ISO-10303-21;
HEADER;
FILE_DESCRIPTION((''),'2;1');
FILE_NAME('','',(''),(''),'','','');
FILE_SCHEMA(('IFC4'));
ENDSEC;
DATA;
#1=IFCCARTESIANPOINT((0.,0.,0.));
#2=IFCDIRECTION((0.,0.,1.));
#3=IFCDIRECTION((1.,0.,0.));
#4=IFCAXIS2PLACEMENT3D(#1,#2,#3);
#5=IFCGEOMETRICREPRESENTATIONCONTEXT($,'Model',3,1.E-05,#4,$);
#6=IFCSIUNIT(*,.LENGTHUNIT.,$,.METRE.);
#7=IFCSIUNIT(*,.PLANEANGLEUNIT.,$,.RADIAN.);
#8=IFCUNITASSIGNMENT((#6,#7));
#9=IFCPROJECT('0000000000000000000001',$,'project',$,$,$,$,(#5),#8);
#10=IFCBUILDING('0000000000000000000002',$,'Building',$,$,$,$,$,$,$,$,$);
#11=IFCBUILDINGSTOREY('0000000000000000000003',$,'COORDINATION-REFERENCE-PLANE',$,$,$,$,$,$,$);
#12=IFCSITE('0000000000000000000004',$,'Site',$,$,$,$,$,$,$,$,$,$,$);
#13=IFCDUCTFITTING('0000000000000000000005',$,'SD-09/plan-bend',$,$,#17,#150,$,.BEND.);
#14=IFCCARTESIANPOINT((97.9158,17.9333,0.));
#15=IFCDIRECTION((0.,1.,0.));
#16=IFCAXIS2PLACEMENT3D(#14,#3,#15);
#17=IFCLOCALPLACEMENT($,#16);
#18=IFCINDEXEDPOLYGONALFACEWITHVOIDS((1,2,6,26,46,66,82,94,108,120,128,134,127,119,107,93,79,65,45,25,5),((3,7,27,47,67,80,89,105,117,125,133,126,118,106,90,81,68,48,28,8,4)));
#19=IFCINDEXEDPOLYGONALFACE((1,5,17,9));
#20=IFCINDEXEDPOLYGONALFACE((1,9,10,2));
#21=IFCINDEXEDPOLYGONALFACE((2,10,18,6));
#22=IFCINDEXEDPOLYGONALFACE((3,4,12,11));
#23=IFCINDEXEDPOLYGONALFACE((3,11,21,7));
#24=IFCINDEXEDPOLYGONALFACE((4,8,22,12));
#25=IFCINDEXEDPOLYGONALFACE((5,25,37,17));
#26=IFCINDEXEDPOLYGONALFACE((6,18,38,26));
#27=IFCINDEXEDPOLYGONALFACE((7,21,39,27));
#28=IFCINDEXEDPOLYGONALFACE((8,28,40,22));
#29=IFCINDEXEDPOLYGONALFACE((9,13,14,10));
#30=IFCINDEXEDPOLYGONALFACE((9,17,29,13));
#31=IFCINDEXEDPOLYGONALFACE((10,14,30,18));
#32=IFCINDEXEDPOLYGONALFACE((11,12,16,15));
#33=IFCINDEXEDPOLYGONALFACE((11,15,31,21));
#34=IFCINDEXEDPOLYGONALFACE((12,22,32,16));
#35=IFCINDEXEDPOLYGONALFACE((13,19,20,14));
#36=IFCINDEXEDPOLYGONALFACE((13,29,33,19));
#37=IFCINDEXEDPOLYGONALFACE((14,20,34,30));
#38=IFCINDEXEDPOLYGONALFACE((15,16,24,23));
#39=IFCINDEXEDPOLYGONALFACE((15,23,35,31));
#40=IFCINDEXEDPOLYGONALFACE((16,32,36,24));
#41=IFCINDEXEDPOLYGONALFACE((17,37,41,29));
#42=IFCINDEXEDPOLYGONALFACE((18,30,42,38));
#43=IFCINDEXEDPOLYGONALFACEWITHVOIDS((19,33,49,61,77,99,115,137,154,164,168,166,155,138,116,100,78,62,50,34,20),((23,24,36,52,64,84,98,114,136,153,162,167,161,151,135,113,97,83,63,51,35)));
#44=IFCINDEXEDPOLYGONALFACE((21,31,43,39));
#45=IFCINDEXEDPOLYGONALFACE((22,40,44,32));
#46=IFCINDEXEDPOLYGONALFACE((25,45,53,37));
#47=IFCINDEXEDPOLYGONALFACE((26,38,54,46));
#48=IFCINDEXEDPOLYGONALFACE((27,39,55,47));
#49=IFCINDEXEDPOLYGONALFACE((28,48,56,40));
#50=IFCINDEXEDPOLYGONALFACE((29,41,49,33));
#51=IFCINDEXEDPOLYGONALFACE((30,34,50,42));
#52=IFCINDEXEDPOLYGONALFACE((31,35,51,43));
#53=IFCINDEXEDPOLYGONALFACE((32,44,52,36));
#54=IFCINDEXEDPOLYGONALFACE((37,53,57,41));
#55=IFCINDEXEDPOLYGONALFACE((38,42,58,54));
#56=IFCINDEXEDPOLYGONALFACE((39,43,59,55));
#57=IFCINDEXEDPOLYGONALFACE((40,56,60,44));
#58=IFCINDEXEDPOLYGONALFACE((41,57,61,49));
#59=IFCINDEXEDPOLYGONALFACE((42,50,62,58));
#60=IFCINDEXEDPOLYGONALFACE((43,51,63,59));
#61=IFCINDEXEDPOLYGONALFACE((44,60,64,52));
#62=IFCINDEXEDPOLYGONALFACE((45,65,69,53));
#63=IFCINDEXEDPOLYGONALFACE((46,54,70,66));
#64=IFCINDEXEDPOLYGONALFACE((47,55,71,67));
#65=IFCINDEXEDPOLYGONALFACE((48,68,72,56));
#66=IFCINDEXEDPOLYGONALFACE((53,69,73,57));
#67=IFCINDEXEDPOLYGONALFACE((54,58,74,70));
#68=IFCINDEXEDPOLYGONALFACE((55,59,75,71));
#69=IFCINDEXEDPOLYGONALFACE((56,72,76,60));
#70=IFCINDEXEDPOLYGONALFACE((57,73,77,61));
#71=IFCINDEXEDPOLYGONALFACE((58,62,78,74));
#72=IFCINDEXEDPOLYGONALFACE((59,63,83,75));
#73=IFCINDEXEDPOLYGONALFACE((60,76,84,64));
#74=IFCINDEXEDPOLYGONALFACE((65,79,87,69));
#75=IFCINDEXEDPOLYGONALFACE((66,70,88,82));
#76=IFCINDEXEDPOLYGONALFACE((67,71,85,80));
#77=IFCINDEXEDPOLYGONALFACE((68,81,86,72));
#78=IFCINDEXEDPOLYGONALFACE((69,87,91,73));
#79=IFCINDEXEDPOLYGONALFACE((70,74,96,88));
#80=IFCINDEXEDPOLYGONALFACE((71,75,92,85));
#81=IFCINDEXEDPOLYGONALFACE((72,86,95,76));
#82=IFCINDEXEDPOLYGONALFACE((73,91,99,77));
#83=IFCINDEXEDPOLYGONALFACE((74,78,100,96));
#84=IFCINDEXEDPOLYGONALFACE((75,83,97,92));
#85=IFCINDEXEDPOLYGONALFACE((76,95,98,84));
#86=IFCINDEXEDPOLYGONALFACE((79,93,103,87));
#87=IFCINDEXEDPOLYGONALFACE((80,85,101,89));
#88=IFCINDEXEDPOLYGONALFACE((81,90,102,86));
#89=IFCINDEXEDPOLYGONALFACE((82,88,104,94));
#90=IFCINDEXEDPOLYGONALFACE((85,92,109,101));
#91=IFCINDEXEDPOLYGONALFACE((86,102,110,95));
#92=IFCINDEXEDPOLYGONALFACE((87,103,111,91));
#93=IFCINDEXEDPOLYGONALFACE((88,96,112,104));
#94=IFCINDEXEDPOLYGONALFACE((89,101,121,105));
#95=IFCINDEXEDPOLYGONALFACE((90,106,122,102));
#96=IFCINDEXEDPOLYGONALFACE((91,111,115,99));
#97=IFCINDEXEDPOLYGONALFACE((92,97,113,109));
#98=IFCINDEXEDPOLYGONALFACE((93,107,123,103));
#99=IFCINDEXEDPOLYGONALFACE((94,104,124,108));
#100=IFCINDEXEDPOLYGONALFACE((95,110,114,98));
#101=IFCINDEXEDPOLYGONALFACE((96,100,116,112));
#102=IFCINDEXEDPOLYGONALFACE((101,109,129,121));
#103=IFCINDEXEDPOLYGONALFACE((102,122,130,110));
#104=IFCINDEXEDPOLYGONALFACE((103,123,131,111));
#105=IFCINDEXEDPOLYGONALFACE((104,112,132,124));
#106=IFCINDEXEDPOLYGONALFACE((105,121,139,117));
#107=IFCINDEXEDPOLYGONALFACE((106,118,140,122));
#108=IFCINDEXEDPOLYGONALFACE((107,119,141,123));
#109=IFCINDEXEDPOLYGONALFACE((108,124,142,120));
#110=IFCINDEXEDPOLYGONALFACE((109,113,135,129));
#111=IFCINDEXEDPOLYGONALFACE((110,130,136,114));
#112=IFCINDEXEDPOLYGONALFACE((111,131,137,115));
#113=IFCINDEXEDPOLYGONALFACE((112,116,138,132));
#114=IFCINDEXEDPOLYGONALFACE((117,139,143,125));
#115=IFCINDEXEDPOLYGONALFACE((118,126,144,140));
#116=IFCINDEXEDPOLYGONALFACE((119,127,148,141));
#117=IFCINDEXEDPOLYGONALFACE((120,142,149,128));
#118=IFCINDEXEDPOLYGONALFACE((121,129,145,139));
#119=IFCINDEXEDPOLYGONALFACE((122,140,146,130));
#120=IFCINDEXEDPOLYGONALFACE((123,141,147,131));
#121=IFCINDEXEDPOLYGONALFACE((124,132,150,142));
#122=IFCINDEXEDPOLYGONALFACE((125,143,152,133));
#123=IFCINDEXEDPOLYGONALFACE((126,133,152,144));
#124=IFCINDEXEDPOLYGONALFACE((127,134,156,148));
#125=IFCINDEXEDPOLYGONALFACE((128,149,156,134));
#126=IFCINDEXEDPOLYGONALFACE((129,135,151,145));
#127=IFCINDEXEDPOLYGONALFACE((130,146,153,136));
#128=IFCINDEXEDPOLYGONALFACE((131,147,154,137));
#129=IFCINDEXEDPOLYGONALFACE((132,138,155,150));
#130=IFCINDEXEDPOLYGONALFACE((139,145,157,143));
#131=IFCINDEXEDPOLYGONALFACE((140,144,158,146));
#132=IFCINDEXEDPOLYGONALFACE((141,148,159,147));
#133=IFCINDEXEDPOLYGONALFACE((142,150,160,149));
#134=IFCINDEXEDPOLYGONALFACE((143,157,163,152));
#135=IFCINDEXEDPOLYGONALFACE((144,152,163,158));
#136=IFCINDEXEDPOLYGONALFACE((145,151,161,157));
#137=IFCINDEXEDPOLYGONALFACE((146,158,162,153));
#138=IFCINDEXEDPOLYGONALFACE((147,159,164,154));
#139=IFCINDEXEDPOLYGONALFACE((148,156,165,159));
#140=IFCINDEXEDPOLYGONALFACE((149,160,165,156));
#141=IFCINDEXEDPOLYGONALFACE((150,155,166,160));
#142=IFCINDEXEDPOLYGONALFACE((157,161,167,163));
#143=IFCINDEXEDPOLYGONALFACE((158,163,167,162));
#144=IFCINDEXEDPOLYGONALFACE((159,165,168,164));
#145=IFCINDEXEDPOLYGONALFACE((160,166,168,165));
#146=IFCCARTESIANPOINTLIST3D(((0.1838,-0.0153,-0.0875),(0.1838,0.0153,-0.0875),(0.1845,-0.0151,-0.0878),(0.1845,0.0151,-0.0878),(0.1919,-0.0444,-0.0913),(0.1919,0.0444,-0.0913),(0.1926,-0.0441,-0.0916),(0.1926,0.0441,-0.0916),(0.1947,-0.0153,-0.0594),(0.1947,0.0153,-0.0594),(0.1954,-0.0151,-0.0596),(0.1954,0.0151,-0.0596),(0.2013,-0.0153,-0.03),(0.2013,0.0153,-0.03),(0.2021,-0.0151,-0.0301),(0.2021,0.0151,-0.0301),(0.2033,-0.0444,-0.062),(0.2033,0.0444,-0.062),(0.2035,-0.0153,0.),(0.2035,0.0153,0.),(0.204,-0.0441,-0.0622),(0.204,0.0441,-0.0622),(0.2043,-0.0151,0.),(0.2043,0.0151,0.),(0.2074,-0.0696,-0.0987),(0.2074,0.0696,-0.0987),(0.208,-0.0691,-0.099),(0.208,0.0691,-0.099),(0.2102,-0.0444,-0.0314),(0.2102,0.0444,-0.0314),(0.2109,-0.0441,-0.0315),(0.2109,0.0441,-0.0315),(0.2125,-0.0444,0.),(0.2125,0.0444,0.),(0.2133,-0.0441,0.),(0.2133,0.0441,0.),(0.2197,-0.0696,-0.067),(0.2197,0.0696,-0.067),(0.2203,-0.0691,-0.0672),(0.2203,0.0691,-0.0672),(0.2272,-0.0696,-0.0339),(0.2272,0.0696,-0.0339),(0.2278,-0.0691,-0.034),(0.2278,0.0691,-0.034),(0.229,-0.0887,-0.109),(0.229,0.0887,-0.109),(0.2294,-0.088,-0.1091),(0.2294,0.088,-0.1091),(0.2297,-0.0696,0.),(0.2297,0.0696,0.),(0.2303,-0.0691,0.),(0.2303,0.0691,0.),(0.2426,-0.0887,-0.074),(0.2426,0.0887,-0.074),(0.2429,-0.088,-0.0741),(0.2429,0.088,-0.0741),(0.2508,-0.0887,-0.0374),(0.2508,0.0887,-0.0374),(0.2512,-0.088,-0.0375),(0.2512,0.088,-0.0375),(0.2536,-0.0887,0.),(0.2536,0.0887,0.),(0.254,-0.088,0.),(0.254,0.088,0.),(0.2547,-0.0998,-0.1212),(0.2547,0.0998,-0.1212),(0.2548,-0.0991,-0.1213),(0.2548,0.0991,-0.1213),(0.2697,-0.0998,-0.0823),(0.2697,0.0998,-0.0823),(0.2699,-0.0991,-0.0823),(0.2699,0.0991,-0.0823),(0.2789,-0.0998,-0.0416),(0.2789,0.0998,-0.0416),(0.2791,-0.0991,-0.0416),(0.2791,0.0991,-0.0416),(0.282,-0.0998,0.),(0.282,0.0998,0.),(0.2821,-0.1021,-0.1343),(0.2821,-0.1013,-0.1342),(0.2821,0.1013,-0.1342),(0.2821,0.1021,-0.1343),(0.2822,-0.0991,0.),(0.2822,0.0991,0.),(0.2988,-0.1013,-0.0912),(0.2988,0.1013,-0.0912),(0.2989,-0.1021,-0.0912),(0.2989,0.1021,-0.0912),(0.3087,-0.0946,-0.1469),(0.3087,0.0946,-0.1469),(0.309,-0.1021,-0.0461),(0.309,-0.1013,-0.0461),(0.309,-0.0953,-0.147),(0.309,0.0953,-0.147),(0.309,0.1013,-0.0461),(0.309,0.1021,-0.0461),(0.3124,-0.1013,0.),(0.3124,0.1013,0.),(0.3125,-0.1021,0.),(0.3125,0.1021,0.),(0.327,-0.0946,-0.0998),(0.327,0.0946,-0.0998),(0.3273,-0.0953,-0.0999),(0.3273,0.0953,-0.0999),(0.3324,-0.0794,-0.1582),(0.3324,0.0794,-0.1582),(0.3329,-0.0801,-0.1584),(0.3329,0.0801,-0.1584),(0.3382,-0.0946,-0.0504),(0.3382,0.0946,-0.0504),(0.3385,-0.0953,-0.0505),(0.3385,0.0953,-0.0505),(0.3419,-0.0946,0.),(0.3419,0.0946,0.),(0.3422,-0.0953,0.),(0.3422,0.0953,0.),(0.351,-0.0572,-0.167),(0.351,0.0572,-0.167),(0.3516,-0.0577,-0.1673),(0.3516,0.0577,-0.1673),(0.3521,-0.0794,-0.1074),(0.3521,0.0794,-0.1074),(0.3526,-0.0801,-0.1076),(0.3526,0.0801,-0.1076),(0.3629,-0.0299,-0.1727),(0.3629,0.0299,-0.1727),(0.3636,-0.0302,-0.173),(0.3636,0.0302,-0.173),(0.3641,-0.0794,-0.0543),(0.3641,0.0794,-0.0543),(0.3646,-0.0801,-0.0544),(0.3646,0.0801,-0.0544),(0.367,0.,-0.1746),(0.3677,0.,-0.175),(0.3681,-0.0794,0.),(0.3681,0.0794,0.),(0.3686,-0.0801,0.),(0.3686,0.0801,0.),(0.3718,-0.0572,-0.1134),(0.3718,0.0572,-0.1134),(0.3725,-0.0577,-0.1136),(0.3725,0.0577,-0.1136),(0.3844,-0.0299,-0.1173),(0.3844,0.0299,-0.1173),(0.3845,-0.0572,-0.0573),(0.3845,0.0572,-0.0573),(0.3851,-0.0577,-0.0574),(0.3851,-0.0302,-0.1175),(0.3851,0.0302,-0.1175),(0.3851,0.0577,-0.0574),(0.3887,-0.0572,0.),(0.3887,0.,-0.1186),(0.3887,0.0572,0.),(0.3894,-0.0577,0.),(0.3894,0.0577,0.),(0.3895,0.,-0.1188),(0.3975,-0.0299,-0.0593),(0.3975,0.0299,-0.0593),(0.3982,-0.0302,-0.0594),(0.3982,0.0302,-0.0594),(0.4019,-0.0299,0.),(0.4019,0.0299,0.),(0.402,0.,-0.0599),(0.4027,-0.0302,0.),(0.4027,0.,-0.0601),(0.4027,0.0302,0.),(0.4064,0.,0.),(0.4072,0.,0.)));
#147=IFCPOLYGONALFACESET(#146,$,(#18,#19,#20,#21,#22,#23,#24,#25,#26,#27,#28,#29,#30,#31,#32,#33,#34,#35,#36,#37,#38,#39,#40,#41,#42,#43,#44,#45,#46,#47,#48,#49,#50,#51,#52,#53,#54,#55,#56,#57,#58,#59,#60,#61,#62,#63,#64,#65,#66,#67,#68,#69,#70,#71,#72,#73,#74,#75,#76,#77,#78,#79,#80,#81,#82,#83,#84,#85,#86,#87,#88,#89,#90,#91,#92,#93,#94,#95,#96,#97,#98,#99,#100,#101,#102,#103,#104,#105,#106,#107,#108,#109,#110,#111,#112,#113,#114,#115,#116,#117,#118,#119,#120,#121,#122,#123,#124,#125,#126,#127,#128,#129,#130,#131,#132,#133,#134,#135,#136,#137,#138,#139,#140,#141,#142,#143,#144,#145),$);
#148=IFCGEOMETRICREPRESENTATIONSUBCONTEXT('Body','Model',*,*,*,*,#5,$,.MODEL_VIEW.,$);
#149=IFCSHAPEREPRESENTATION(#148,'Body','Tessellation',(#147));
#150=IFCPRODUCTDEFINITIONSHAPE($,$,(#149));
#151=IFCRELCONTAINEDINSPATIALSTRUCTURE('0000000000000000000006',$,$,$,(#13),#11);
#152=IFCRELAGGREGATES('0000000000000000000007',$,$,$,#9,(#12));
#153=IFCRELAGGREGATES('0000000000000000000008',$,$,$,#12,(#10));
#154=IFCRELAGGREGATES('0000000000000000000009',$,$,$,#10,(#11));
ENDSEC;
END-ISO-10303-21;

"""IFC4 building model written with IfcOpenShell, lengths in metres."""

from ifc_helpers import new_model, entity, si_unit, frame, origin_with_axes, place, context, subcontext, project, spatial, element, save


model = new_model("IFC4")

# Units and contexts
model_context = context("Model", 3, precision=1e-05, world=origin_with_axes())
body_context_1 = subcontext(model_context, "Body", "Model", "MODEL_VIEW")
ifc_project = project(units=[si_unit("LENGTHUNIT", "METRE"), si_unit("PLANEANGLEUNIT", "RADIAN")], contexts=[model_context])

# Site, building, storey
site = spatial("IfcSite", under=ifc_project, Name="Site")
building = spatial("IfcBuilding", under=site, Name="Building")
storey = spatial("IfcBuildingStorey", under=building, Name="COORDINATION-REFERENCE-PLANE")

# Duct fitting
duct_fitting_1_placement = place(None, frame((97.9158, 17.9333, 0.0), z_axis=(1.0, 0.0, 0.0), x_axis=(0.0, 1.0, 0.0)))
element("IfcDuctFitting", 1, at=duct_fitting_1_placement, inside=storey, Name="SD-09/plan-bend", PredefinedType="BEND", context=body_context_1, shape_type="SweptSolid", body=[
    entity("IfcRevolvedAreaSolid", entity("IfcCircleHollowProfileDef", "AREA", None, entity("IfcAxis2Placement2D", entity("IfcCartesianPoint", [0.3048, 0.0])), 0.1024, 0.0008), entity("IfcAxis2Placement3D", entity("IfcCartesianPoint", [0.0, 0.0, 0.0]), entity("IfcDirection", [0.0, 0.0, 1.0]), entity("IfcDirection", [1.0, 0.0, 0.0])), entity("IfcAxis1Placement", entity("IfcCartesianPoint", [0.0, 0.0, 0.0]), entity("IfcDirection", [0.0, 1.0, 0.0])), 0.444153),
])

save(model, "model.ifc")
